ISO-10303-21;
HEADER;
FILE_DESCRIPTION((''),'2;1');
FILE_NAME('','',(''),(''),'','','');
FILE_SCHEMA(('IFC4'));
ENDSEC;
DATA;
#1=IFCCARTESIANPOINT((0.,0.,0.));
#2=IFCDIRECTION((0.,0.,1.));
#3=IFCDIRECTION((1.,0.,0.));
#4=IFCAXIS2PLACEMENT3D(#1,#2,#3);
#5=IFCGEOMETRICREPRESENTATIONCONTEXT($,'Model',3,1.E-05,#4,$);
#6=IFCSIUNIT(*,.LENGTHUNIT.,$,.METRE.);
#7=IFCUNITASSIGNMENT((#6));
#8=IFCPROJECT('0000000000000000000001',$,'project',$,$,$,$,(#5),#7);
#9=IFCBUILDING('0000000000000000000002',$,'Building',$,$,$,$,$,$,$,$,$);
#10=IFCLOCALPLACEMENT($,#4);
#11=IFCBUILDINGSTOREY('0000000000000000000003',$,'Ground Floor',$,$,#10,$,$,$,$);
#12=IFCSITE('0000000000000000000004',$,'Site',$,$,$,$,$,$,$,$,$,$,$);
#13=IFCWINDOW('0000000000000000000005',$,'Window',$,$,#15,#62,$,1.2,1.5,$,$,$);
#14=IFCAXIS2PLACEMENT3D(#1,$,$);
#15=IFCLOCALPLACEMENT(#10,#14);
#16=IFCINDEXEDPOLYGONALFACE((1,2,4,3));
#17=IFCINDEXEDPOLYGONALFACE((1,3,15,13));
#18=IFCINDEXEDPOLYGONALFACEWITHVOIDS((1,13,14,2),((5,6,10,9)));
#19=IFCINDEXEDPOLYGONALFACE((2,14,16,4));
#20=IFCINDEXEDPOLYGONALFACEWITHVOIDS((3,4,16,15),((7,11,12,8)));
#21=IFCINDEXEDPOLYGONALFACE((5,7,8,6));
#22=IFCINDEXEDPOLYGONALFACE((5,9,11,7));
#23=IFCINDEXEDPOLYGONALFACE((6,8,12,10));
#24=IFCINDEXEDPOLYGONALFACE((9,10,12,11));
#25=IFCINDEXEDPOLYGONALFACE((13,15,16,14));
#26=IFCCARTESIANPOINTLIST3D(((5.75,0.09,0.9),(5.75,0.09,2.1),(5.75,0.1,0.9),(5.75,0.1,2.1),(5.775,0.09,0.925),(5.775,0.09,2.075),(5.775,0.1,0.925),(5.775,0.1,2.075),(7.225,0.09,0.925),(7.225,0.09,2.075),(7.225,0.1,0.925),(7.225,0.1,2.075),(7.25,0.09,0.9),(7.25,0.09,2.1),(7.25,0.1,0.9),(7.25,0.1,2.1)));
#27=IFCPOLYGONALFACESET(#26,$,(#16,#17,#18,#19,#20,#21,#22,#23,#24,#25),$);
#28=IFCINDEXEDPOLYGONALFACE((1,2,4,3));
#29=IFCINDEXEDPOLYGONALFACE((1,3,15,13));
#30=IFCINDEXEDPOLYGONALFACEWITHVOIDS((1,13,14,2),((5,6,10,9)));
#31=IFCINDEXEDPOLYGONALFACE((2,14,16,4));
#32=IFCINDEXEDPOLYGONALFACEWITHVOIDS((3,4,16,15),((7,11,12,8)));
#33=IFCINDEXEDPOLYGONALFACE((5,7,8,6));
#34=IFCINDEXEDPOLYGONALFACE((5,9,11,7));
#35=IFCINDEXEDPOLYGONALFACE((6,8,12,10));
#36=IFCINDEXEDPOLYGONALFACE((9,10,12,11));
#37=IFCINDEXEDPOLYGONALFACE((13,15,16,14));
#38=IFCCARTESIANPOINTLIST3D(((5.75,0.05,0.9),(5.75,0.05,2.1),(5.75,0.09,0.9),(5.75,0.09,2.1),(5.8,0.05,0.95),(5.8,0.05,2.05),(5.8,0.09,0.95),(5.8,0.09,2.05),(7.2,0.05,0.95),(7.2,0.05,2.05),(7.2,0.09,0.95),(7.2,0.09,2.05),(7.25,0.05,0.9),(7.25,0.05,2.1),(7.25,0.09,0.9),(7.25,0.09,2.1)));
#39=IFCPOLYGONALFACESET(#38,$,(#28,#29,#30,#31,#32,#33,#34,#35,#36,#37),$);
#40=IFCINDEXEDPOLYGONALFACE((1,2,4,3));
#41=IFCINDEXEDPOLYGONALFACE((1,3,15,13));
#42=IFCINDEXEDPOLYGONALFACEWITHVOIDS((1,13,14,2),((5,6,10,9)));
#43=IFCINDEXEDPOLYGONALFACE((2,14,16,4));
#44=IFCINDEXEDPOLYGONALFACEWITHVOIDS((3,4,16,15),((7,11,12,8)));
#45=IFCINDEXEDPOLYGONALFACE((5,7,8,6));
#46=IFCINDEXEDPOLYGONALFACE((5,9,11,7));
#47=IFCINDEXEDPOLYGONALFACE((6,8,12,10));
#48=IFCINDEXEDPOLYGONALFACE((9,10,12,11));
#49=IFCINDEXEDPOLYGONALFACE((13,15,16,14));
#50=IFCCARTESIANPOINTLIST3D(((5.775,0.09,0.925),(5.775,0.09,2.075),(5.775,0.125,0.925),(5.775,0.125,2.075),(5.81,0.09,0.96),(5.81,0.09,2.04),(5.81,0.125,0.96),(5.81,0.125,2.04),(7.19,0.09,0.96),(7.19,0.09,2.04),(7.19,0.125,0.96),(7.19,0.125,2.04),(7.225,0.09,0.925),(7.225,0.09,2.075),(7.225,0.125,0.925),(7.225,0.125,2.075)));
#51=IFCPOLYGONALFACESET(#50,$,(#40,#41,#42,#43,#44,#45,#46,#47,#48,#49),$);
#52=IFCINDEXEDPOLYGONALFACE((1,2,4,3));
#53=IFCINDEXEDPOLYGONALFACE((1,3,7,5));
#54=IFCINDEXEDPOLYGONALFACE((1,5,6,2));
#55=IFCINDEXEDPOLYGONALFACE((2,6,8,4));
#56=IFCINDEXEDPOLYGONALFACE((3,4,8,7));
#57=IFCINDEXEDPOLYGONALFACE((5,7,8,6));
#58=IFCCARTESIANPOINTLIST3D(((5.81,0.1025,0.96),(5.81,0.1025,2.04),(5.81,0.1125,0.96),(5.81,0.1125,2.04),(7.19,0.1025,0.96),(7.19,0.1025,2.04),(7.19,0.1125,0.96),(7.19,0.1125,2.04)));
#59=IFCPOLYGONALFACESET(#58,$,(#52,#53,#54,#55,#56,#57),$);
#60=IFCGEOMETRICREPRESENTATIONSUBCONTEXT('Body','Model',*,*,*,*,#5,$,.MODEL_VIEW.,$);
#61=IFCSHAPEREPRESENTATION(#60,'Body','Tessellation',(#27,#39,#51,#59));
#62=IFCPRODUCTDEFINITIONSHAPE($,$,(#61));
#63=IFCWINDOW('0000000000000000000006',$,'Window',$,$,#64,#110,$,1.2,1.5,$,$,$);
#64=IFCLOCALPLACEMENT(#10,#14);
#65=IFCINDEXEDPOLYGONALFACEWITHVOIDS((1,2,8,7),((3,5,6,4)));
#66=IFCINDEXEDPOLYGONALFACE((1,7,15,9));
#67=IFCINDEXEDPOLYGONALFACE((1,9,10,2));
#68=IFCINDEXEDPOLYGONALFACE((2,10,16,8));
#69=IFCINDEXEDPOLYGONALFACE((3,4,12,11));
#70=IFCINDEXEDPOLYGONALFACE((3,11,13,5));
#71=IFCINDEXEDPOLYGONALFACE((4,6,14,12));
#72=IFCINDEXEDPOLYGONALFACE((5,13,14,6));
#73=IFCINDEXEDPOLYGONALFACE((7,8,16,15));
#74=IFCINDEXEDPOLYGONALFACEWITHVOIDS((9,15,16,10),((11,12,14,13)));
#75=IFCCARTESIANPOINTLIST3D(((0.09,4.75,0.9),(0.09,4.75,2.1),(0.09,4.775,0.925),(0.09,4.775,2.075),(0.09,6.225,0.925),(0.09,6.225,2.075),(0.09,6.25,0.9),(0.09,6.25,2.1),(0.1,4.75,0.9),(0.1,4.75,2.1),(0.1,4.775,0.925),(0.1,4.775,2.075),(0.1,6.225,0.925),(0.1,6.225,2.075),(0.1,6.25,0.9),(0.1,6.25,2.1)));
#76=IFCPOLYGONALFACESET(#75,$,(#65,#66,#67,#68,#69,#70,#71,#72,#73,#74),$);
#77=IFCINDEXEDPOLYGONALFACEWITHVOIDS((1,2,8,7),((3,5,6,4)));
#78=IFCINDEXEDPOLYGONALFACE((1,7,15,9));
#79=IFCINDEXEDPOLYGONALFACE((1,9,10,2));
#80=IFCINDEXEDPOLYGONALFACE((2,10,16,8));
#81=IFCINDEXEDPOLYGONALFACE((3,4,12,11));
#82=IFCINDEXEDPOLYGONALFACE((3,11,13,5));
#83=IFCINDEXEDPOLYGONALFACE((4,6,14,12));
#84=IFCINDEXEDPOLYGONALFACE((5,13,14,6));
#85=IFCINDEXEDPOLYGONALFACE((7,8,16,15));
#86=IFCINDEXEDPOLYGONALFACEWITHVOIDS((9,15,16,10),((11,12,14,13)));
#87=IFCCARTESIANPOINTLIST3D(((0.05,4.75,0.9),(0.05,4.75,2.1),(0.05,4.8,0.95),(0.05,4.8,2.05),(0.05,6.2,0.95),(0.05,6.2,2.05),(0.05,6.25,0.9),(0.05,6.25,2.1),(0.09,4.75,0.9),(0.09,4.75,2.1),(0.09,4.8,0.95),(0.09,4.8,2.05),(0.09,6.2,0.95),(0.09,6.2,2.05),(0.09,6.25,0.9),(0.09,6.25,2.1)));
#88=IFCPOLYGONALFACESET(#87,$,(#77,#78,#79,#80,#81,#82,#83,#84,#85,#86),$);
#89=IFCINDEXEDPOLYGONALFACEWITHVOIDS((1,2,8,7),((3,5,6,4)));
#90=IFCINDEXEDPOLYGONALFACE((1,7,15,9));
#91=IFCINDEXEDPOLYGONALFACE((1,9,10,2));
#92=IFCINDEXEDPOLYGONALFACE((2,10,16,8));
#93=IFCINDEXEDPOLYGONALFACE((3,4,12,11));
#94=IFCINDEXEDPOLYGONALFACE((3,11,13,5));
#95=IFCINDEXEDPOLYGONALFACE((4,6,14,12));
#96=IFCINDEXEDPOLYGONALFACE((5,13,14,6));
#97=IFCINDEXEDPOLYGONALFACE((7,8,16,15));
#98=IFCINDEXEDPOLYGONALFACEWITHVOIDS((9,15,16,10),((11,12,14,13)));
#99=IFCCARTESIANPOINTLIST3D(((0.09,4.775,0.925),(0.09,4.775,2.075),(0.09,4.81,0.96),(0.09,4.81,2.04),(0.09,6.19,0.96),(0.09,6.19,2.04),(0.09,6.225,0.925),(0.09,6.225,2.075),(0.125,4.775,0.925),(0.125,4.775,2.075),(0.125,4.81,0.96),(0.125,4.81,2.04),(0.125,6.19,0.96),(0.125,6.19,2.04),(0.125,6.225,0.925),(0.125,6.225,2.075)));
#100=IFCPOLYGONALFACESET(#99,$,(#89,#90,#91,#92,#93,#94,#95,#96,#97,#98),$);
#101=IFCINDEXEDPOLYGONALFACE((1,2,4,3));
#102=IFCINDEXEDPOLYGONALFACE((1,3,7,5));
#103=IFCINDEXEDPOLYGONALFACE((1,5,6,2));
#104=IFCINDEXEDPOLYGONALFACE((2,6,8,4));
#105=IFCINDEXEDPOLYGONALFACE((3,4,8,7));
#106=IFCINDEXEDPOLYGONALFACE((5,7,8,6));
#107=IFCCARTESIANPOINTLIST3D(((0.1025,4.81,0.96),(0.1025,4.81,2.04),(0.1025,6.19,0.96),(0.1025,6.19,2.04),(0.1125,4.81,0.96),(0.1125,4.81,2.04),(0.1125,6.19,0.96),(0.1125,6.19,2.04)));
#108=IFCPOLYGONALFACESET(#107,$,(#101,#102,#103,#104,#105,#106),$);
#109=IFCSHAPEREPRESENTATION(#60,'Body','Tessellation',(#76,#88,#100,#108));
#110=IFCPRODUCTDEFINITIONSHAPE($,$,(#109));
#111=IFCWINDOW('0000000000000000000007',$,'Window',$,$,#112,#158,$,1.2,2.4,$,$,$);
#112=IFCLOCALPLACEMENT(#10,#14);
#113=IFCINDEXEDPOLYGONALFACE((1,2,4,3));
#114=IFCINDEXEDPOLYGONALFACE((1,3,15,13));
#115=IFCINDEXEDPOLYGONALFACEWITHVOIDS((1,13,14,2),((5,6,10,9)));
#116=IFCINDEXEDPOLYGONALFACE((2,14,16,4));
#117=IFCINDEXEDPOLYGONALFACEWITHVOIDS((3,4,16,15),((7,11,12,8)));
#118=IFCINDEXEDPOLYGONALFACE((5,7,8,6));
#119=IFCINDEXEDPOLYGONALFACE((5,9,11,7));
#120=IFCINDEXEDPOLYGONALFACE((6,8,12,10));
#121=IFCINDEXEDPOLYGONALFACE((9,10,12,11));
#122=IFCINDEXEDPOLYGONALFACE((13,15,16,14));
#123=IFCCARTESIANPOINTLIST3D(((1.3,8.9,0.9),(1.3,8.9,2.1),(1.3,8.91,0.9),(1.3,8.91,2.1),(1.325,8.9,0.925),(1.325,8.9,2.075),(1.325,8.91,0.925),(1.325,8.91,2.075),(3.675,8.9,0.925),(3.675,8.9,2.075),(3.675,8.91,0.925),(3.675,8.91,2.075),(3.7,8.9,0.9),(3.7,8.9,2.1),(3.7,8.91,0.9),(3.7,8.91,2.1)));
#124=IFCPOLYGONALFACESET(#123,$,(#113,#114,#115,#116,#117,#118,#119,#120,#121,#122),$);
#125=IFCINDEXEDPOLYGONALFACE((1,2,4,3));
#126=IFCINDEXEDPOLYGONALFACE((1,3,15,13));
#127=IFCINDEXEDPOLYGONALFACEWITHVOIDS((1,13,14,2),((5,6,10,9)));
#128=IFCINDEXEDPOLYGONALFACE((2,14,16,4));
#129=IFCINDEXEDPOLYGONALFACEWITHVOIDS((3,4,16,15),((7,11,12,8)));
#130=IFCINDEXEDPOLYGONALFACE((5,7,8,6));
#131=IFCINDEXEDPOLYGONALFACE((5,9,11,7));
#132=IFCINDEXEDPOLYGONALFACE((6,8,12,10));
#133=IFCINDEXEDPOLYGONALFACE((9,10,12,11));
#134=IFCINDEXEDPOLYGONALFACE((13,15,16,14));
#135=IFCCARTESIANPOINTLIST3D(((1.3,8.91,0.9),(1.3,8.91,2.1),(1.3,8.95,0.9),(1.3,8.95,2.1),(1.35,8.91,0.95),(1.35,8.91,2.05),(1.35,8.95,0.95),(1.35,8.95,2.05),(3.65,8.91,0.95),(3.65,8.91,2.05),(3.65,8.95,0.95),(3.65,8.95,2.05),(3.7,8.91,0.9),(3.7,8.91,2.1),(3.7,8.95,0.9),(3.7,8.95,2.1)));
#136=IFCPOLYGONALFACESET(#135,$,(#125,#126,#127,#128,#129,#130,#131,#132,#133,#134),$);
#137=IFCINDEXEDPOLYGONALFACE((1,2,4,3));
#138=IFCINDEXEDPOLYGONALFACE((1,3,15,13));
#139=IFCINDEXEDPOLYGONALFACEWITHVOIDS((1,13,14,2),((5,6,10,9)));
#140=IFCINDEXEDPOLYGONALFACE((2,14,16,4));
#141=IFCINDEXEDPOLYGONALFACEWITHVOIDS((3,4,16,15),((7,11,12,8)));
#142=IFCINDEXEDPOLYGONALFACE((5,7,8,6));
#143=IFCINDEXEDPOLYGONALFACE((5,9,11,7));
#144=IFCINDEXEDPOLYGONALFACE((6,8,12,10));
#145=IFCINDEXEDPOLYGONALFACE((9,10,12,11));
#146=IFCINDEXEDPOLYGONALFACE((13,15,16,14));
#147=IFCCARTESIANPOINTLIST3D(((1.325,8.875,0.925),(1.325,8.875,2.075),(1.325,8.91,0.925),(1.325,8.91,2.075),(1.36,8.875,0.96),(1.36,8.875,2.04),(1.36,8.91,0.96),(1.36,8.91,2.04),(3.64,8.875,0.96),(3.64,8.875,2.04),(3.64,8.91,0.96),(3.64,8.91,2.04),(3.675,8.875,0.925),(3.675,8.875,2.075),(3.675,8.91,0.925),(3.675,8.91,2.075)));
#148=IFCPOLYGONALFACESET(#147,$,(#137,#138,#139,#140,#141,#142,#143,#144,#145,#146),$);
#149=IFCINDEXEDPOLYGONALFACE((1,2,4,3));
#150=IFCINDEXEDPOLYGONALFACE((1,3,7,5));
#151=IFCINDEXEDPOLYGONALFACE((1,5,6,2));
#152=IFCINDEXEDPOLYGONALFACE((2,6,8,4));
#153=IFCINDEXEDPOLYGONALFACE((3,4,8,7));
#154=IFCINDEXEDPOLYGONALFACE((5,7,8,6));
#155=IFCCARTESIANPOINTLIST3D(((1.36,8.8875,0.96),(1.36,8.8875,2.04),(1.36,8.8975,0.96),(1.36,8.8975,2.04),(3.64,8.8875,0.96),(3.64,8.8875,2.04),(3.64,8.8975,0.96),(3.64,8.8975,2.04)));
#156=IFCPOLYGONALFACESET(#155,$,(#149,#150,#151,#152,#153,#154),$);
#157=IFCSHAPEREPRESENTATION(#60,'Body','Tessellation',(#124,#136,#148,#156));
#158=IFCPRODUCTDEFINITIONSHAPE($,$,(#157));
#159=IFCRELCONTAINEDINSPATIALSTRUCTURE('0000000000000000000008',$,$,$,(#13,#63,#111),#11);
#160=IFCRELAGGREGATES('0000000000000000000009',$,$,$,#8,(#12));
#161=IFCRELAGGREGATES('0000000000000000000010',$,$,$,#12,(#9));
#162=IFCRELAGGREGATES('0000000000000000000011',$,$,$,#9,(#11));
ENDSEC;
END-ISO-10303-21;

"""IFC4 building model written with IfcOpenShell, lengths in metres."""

from ifc_helpers import new_model, si_unit, frame, origin_with_axes, place, context, subcontext, project, spatial, line, indexed_curve, outline, extrude, element, save


model = new_model("IFC4")

# Units and contexts
model_context = context("Model", 3, precision=1e-05, world=origin_with_axes())
body_context = subcontext(model_context, "Body", "Model", "MODEL_VIEW")
ifc_project = project(units=[si_unit("LENGTHUNIT", "METRE")], contexts=[model_context])

# Site, building, storey
site = spatial("IfcSite", under=ifc_project, Name="Site")
building = spatial("IfcBuilding", under=site, Name="Building")
storey_placement = place(None, origin_with_axes())
storey = spatial("IfcBuildingStorey", under=building, at=storey_placement, Name="Ground Floor")

# Windows
for number, where, z_axis, x_axis, name in (
    (1, (5.75, 0.0, 0.9), (0.0, 0.0, 1.0), (1.0, 0.0, 0.0), "Window"),
    (2, (0.0, 6.25, 0.9), (0.0, 0.0, 1.0), (0.0, -1.0, 0.0), "Window"),
):
    element("IfcWindow", number, at=place(storey_placement, frame(where, z_axis=z_axis, x_axis=x_axis)), inside=storey, Name=name, OverallHeight=1.2, OverallWidth=1.5, context=body_context, shape_type="SweptSolid", body=[
        extrude(outline(indexed_curve([(0.0, 0.0), (1.5, 0.0), (1.5, 1.2), (0.0, 1.2)], segments=[line(1, 2, 3, 4, 1)]), holes=[indexed_curve([(0.025, 0.025), (1.475, 0.025), (1.475, 1.175), (0.025, 1.175)], segments=[line(1, 2, 3, 4, 1)])]), frame((0.0, 0.09, 0.0), z_axis=(0.0, -1.0, 0.0), x_axis=(1.0, 0.0, 0.0)), (0.0, 0.0, -1.0), 0.01),
        extrude(outline(indexed_curve([(0.0, 0.0), (1.5, 0.0), (1.5, 1.2), (0.0, 1.2)], segments=[line(1, 2, 3, 4, 1)]), holes=[indexed_curve([(0.05, 0.05), (1.45, 0.05), (1.45, 1.15), (0.05, 1.15)], segments=[line(1, 2, 3, 4, 1)])]), frame((0.0, 0.05, 0.0), z_axis=(0.0, -1.0, 0.0), x_axis=(1.0, 0.0, 0.0)), (0.0, 0.0, -1.0), 0.04),
        extrude(outline(indexed_curve([(0.0, 0.0), (1.45, 0.0), (1.45, 1.15), (0.0, 1.15)], segments=[line(1, 2, 3, 4, 1)]), holes=[indexed_curve([(0.035, 0.035), (1.415, 0.035), (1.415, 1.115), (0.035, 1.115)], segments=[line(1, 2, 3, 4, 1)])]), frame((0.025, 0.09, 0.025), z_axis=(0.0, -1.0, 0.0), x_axis=(1.0, 0.0, 0.0)), (0.0, 0.0, -1.0), 0.035),
        extrude(outline(indexed_curve([(0.035, 0.035), (1.415, 0.035), (1.415, 1.115), (0.035, 1.115)], segments=[line(1, 2, 3, 4, 1)])), frame((0.025, 0.1025, 0.025), z_axis=(0.0, -1.0, 0.0), x_axis=(1.0, 0.0, 0.0)), (0.0, 0.0, -1.0), 0.01),
    ])
window_1_placement = place(storey_placement, frame((3.7, 9.0, 0.9), z_axis=(0.0, 0.0, 1.0), x_axis=(-1.0, 0.0, 0.0)))
element("IfcWindow", 3, at=window_1_placement, inside=storey, Name="Window", OverallHeight=1.2, OverallWidth=2.4, context=body_context, shape_type="SweptSolid", body=[
    extrude(outline(indexed_curve([(0.0, 0.0), (2.4, 0.0), (2.4, 1.2), (0.0, 1.2)], segments=[line(1, 2, 3, 4, 1)]), holes=[indexed_curve([(0.025, 0.025), (2.375, 0.025), (2.375, 1.175), (0.025, 1.175)], segments=[line(1, 2, 3, 4, 1)])]), frame((0.0, 0.09, 0.0), z_axis=(0.0, -1.0, 0.0), x_axis=(1.0, 0.0, 0.0)), (0.0, 0.0, -1.0), 0.01),
    extrude(outline(indexed_curve([(0.0, 0.0), (2.4, 0.0), (2.4, 1.2), (0.0, 1.2)], segments=[line(1, 2, 3, 4, 1)]), holes=[indexed_curve([(0.05, 0.05), (2.35, 0.05), (2.35, 1.15), (0.05, 1.15)], segments=[line(1, 2, 3, 4, 1)])]), frame((0.0, 0.05, 0.0), z_axis=(0.0, -1.0, 0.0), x_axis=(1.0, 0.0, 0.0)), (0.0, 0.0, -1.0), 0.04),
    extrude(outline(indexed_curve([(0.0, 0.0), (2.35, 0.0), (2.35, 1.15), (0.0, 1.15)], segments=[line(1, 2, 3, 4, 1)]), holes=[indexed_curve([(0.035, 0.035), (2.315, 0.035), (2.315, 1.115), (0.035, 1.115)], segments=[line(1, 2, 3, 4, 1)])]), frame((0.025, 0.09, 0.025), z_axis=(0.0, -1.0, 0.0), x_axis=(1.0, 0.0, 0.0)), (0.0, 0.0, -1.0), 0.035),
    extrude(outline(indexed_curve([(0.035, 0.035), (2.315, 0.035), (2.315, 1.115), (0.035, 1.115)], segments=[line(1, 2, 3, 4, 1)])), frame((0.025, 0.1025, 0.025), z_axis=(0.0, -1.0, 0.0), x_axis=(1.0, 0.0, 0.0)), (0.0, 0.0, -1.0), 0.01),
])

save(model, "model.ifc")
